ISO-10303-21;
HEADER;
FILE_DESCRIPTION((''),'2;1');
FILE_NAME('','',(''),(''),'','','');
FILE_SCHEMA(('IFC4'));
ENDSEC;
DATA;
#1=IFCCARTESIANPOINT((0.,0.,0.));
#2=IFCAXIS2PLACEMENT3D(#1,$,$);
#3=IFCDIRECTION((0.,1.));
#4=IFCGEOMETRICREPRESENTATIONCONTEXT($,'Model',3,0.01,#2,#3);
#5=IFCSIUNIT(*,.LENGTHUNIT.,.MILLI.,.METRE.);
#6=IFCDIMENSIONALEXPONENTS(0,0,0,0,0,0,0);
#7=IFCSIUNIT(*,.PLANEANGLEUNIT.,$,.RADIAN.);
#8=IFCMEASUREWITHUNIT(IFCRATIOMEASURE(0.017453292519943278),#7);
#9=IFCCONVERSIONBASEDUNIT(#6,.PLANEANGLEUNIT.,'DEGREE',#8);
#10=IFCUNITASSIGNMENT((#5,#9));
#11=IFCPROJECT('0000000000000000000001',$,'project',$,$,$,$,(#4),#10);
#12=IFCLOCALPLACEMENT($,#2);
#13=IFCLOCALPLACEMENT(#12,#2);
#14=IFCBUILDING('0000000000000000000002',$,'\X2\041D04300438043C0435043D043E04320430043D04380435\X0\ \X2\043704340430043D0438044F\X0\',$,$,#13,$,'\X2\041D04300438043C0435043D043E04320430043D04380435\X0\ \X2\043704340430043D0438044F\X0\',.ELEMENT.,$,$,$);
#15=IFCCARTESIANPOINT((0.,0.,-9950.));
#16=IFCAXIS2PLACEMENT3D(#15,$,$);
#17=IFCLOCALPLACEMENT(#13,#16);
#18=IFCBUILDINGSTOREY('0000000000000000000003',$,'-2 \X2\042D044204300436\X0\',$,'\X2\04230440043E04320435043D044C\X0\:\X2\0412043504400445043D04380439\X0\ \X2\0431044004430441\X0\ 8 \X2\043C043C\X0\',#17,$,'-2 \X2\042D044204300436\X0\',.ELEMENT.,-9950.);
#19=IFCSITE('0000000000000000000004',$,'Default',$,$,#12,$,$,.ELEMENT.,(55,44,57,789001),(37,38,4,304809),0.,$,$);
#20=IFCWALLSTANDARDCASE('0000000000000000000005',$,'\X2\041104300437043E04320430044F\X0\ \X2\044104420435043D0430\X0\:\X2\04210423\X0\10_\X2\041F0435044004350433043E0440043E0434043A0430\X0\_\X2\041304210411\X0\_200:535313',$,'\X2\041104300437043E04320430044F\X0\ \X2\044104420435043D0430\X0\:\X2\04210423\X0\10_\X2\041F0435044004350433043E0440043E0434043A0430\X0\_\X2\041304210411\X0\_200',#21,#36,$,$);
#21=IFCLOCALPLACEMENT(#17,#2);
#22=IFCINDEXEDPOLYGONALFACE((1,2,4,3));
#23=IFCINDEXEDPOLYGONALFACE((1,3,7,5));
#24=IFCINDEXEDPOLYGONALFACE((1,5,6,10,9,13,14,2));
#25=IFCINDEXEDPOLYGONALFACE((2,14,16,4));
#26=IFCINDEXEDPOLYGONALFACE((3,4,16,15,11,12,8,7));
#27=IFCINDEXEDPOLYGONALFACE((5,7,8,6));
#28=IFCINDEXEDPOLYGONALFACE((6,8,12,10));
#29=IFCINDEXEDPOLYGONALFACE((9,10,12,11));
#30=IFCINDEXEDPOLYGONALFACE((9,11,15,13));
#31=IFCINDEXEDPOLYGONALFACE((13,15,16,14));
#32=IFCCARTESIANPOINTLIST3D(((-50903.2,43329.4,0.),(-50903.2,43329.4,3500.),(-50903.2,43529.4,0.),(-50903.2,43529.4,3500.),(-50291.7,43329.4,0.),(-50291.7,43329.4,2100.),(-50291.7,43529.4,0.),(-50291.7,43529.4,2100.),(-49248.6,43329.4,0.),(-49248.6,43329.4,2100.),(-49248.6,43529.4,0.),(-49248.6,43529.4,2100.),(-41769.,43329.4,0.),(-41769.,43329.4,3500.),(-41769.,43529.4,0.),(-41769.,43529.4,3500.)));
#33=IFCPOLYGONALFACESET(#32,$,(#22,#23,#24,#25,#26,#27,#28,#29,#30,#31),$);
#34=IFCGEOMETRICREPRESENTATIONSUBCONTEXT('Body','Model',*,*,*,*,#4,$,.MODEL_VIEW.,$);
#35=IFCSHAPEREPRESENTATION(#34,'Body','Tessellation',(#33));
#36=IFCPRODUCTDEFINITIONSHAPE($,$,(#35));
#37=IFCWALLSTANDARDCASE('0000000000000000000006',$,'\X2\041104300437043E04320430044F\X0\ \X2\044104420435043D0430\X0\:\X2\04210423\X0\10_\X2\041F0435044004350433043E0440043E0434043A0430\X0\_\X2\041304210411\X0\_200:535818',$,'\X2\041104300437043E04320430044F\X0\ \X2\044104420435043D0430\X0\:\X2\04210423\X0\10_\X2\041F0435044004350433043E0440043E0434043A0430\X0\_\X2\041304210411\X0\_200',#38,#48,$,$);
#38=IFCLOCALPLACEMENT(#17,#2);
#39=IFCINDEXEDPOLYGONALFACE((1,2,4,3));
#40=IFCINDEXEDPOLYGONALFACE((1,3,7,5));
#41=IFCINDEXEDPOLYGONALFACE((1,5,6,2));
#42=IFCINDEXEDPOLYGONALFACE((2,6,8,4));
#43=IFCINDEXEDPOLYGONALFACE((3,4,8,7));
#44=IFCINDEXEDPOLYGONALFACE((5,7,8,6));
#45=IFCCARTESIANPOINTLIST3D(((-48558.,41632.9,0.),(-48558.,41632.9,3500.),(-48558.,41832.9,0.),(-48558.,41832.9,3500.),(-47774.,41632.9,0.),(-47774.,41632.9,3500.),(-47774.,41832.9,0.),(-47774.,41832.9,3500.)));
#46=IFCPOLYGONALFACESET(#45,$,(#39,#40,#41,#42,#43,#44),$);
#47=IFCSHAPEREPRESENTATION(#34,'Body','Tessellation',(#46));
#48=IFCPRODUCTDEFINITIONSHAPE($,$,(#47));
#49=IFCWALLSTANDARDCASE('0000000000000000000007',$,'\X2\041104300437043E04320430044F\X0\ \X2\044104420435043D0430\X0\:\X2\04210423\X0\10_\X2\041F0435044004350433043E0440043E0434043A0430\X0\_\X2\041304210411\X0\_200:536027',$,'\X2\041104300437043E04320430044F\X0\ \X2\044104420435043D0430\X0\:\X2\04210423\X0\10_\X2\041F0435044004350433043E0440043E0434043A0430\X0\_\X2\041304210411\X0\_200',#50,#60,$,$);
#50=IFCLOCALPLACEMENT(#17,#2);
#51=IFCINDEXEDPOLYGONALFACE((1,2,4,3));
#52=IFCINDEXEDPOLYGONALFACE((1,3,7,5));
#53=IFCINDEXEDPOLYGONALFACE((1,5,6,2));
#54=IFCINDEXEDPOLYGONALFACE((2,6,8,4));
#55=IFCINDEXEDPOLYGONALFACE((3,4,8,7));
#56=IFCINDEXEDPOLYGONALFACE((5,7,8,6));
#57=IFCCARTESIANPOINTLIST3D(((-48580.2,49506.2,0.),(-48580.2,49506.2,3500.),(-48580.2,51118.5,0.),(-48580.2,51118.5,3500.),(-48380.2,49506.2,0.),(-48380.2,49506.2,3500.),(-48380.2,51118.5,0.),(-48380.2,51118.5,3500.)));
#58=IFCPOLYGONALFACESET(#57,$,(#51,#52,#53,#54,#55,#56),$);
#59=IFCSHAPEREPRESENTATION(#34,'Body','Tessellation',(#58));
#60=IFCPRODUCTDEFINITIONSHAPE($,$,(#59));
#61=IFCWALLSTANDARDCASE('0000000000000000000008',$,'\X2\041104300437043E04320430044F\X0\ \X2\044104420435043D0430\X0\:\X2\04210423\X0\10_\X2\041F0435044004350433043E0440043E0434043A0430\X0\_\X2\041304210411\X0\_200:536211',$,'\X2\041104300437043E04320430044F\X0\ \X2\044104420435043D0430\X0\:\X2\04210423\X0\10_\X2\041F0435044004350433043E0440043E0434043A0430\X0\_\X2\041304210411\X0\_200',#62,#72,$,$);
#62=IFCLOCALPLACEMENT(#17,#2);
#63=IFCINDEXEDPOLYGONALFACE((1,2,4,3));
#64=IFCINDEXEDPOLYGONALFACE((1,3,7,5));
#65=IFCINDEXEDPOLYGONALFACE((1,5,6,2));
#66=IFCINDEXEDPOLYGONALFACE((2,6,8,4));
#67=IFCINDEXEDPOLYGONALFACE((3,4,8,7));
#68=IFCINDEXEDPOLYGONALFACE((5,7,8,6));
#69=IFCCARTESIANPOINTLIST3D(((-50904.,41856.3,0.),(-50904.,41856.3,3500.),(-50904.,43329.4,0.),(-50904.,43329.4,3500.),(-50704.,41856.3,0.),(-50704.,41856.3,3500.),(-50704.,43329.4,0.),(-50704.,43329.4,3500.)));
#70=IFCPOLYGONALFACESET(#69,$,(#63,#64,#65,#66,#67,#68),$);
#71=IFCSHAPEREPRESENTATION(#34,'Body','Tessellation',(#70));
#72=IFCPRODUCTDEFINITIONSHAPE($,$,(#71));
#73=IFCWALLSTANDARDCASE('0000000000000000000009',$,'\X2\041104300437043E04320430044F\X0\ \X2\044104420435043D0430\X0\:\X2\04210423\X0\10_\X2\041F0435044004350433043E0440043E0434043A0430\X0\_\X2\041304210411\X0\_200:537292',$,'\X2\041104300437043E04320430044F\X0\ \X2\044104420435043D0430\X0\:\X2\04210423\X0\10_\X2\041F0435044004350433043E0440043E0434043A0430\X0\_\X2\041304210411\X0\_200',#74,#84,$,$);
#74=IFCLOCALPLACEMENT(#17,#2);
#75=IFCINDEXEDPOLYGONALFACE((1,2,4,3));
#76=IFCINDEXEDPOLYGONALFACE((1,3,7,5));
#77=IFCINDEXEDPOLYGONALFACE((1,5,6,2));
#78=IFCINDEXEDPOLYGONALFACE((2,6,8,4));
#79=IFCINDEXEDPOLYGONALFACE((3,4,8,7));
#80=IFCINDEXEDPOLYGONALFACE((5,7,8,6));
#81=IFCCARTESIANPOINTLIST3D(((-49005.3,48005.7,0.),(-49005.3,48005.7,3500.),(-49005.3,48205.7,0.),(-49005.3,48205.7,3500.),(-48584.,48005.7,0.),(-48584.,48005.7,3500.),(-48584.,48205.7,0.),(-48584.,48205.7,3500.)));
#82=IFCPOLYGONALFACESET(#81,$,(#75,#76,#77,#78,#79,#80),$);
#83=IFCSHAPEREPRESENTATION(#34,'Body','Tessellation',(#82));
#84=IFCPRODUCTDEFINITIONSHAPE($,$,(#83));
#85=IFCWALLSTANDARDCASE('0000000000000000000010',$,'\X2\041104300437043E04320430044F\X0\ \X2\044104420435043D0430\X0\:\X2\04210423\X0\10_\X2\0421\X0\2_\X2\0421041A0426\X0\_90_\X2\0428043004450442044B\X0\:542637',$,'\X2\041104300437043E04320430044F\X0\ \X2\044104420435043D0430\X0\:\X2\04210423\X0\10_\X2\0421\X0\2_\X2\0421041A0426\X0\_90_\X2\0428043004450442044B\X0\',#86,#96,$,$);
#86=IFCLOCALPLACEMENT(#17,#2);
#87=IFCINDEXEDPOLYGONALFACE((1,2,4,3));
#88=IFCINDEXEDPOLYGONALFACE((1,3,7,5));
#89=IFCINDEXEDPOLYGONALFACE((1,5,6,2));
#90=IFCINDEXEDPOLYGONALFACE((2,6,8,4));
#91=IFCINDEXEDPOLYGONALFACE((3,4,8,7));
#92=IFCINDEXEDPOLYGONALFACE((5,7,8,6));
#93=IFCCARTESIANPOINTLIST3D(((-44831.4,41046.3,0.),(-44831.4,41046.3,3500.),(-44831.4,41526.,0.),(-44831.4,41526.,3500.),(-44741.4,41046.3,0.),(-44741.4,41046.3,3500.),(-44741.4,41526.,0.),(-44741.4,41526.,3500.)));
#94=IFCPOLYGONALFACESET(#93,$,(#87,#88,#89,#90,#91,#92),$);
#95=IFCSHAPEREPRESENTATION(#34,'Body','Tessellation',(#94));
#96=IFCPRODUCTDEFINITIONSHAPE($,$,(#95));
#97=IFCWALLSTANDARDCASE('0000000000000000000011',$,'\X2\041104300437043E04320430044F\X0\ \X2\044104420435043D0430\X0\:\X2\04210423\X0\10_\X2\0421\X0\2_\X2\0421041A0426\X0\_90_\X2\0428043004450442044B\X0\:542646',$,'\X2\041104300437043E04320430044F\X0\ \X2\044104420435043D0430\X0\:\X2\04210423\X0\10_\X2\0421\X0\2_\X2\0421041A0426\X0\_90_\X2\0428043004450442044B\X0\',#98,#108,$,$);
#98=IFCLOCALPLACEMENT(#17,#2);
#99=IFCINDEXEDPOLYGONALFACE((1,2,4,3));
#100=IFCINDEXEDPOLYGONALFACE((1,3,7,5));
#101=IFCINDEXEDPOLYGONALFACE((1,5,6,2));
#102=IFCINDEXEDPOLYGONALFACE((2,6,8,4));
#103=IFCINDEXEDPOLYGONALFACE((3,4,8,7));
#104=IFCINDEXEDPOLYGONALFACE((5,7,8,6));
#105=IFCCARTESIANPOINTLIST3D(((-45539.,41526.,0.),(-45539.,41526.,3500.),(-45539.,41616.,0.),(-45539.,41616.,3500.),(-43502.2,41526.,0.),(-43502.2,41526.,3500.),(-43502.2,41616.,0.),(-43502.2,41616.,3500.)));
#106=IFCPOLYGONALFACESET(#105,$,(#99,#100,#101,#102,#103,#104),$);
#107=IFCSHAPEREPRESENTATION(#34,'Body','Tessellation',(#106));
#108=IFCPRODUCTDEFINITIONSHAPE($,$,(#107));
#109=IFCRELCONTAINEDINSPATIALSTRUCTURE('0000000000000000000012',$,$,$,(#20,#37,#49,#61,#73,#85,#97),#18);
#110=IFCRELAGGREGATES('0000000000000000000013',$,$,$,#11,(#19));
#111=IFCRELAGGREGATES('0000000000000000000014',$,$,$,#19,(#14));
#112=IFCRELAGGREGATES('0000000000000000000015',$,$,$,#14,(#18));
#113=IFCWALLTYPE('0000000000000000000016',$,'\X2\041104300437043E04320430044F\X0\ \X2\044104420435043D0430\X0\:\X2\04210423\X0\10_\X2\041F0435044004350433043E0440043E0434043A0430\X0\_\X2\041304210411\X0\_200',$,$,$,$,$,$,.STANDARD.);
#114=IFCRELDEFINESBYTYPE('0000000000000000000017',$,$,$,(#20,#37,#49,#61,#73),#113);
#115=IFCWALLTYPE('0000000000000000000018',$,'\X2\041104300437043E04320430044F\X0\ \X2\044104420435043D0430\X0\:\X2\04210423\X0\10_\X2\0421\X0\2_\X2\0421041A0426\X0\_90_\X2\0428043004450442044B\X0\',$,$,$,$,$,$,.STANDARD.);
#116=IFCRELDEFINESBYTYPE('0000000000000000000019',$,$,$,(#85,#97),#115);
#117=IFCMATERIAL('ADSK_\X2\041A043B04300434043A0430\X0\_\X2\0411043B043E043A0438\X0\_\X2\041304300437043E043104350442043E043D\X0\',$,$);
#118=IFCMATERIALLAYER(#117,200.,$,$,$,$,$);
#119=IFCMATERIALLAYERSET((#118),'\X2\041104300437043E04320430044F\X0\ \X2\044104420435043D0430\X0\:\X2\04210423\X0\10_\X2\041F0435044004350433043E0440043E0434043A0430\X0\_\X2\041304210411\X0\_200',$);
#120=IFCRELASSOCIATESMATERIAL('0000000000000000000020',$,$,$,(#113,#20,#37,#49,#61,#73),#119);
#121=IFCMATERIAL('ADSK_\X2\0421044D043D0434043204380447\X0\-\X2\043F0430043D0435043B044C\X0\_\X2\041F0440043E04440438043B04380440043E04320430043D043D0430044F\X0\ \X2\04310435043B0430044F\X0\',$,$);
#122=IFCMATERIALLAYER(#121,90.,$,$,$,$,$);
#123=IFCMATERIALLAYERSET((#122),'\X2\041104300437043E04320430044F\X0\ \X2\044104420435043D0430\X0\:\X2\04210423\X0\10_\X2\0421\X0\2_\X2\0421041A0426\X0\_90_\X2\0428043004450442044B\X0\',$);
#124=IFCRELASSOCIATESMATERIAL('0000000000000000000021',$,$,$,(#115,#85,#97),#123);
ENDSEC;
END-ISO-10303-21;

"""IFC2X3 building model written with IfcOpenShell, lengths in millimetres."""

from ifc_helpers import new_model, entity, si_unit, converted_unit, direction, frame, frame_2d, origin, place, context, subcontext, project, spatial, rectangle, extrude, material, layer, layer_set, layer_usage, type_object, element, save


model = new_model("IFC2X3")

# Units and contexts
model_context = context("Model", 3, precision=0.01, world=origin(), true_north=direction((0.0, 1.0)))
body_context = subcontext(model_context, "Body", "Model", "MODEL_VIEW")
ifc_project = project(units=[si_unit("LENGTHUNIT", "METRE", prefix="MILLI"), converted_unit("PLANEANGLEUNIT", "DEGREE", entity("IfcRatioMeasure", 0.017453292519943278), si_unit("PLANEANGLEUNIT", "RADIAN"), dimensions=[0, 0, 0, 0, 0, 0, 0])], contexts=[model_context])

# Site, building, storey
site_placement = place(None, origin())
site = spatial("IfcSite", under=ifc_project, at=site_placement, Name="Default", CompositionType="ELEMENT", RefLatitude=(55, 44, 57, 789001), RefLongitude=(37, 38, 4, 304809), RefElevation=0.0)
building_placement = place(site_placement, origin())
building = spatial("IfcBuilding", under=site, at=building_placement, Name="Наименование здания", LongName="Наименование здания", CompositionType="ELEMENT")
storey_placement = place(building_placement, frame((0.0, 0.0, -9950.0)))
storey = spatial("IfcBuildingStorey", under=building, at=storey_placement, Name="-2 Этаж", ObjectType="Уровень:Верхний брус 8 мм", LongName="-2 Этаж", CompositionType="ELEMENT", Elevation=-9950.0)

# Shared definitions
ifc_material_1 = material(Name="ADSK_Сэндвич-панель_Профилированная белая")

# Shared definitions
ifc_material_2 = material(Name="ADSK_Кладка_Блоки_Газобетон")
ifc_layer_1 = layer(ifc_material_2, 200.0)
ifc_layer_set_1 = layer_set([ifc_layer_1], Name="Базовая стена:СУ10_Перегородка_ГСБ_200")
ifc_layer_usage_1 = layer_usage(ifc_layer_set_1, "AXIS2", "NEGATIVE", 100.0)
wall_type_1 = type_object("IfcWallType", Name="Базовая стена:СУ10_Перегородка_ГСБ_200", PredefinedType="STANDARD", material=ifc_layer_set_1)

# Wall, opening
wall_1_placement = place(storey_placement, frame((-41769.0, 43429.4, 0.0), z_axis=(0.0, 0.0, 1.0), x_axis=(-1.0, 0.0, 0.0)))
wall_1 = element("IfcWallStandardCase", 1, at=wall_1_placement, inside=storey, type_object=wall_type_1, material=ifc_layer_usage_1, Name="Базовая стена:СУ10_Перегородка_ГСБ_200:535313", ObjectType="Базовая стена:СУ10_Перегородка_ГСБ_200", context=body_context, shape_type="SweptSolid", body=[
    extrude(rectangle(XDim=9134.2, YDim=200.0, at=frame_2d((4567.1, 0.0), x_axis=(-1.0, 0.0))), origin(), (0.0, 0.0, 1.0), 3500.0),
])
opening_1_placement = place(wall_1_placement, origin())
element("IfcOpeningElement", 2, at=opening_1_placement, cuts=wall_1, ObjectType="Opening", context=body_context, shape_type="SweptSolid", body=[
    extrude(rectangle(XDim=2100.0, YDim=1043.2, at=frame_2d((0.0, 0.0), x_axis=(1.0, 0.0))), frame((8001.1, -100.0, 1050.0), z_axis=(0.0, 1.0, 0.0), x_axis=(0.0, 0.0, -1.0)), (0.0, 0.0, 1.0), 200.0),
])

# Walls
wall_2_placement = place(storey_placement, frame((-47774.0, 41732.9, 0.0), z_axis=(0.0, 0.0, 1.0), x_axis=(-1.0, 0.0, 0.0)))
element("IfcWallStandardCase", 3, at=wall_2_placement, inside=storey, type_object=wall_type_1, material=ifc_layer_usage_1, Name="Базовая стена:СУ10_Перегородка_ГСБ_200:535818", ObjectType="Базовая стена:СУ10_Перегородка_ГСБ_200", context=body_context, shape_type="SweptSolid", body=[
    extrude(rectangle(XDim=784.0, YDim=200.0, at=frame_2d((392.0, 0.0), x_axis=(-1.0, 0.0))), origin(), (0.0, 0.0, 1.0), 3500.0),
])
wall_3_placement = place(storey_placement, frame((-48480.2, 49506.2, 0.0), z_axis=(0.0, 0.0, 1.0), x_axis=(0.0, 1.0, 0.0)))
element("IfcWallStandardCase", 4, at=wall_3_placement, inside=storey, type_object=wall_type_1, material=ifc_layer_usage_1, Name="Базовая стена:СУ10_Перегородка_ГСБ_200:536027", ObjectType="Базовая стена:СУ10_Перегородка_ГСБ_200", context=body_context, shape_type="SweptSolid", body=[
    extrude(rectangle(XDim=1612.2, YDim=200.0, at=frame_2d((806.1, 0.0), x_axis=(-1.0, 0.0))), origin(), (0.0, 0.0, 1.0), 3500.0),
])
wall_4_placement = place(storey_placement, frame((-50804.0, 41856.3, 0.0), z_axis=(0.0, 0.0, 1.0), x_axis=(0.0, 1.0, 0.0)))
element("IfcWallStandardCase", 5, at=wall_4_placement, inside=storey, type_object=wall_type_1, material=ifc_layer_usage_1, Name="Базовая стена:СУ10_Перегородка_ГСБ_200:536211", ObjectType="Базовая стена:СУ10_Перегородка_ГСБ_200", context=body_context, shape_type="SweptSolid", body=[
    extrude(rectangle(XDim=1473.1, YDim=200.0, at=frame_2d((736.6, 0.0), x_axis=(-1.0, 0.0))), origin(), (0.0, 0.0, 1.0), 3500.0),
])
wall_5_placement = place(storey_placement, frame((-48584.0, 48105.7, 0.0), z_axis=(0.0, 0.0, 1.0), x_axis=(-1.0, 0.0, 0.0)))
element("IfcWallStandardCase", 6, at=wall_5_placement, inside=storey, type_object=wall_type_1, material=ifc_layer_usage_1, Name="Базовая стена:СУ10_Перегородка_ГСБ_200:537292", ObjectType="Базовая стена:СУ10_Перегородка_ГСБ_200", context=body_context, shape_type="SweptSolid", body=[
    extrude(rectangle(XDim=421.3, YDim=200.0, at=frame_2d((210.7, 0.0), x_axis=(-1.0, 0.0))), origin(), (0.0, 0.0, 1.0), 3500.0),
])
ifc_layer_2 = layer(ifc_material_1, 90.0)
ifc_layer_set_2 = layer_set([ifc_layer_2], Name="Базовая стена:СУ10_С2_СКЦ_90_Шахты")
ifc_layer_usage_2 = layer_usage(ifc_layer_set_2, "AXIS2", "NEGATIVE", 45.0)
wall_type_2 = type_object("IfcWallType", Name="Базовая стена:СУ10_С2_СКЦ_90_Шахты", PredefinedType="STANDARD", material=ifc_layer_set_2)
wall_6_placement = place(storey_placement, frame((-44786.4, 41046.3, 0.0), z_axis=(0.0, 0.0, 1.0), x_axis=(0.0, 1.0, 0.0)))
element("IfcWallStandardCase", 7, at=wall_6_placement, inside=storey, type_object=wall_type_2, material=ifc_layer_usage_2, Name="Базовая стена:СУ10_С2_СКЦ_90_Шахты:542637", ObjectType="Базовая стена:СУ10_С2_СКЦ_90_Шахты", context=body_context, shape_type="SweptSolid", body=[
    extrude(rectangle(XDim=479.7, YDim=90.0, at=frame_2d((239.8, 0.0), x_axis=(-1.0, 0.0))), origin(), (0.0, 0.0, 1.0), 3500.0),
])
wall_7_placement = place(storey_placement, frame((-43502.2, 41571.0, 0.0), z_axis=(0.0, 0.0, 1.0), x_axis=(-1.0, 0.0, 0.0)))
element("IfcWallStandardCase", 8, at=wall_7_placement, inside=storey, type_object=wall_type_2, material=ifc_layer_usage_2, Name="Базовая стена:СУ10_С2_СКЦ_90_Шахты:542646", ObjectType="Базовая стена:СУ10_С2_СКЦ_90_Шахты", context=body_context, shape_type="SweptSolid", body=[
    extrude(rectangle(XDim=2036.9, YDim=90.0, at=frame_2d((1018.4, 0.0), x_axis=(-1.0, 0.0))), origin(), (0.0, 0.0, 1.0), 3500.0),
])

save(model, "model.ifc")
